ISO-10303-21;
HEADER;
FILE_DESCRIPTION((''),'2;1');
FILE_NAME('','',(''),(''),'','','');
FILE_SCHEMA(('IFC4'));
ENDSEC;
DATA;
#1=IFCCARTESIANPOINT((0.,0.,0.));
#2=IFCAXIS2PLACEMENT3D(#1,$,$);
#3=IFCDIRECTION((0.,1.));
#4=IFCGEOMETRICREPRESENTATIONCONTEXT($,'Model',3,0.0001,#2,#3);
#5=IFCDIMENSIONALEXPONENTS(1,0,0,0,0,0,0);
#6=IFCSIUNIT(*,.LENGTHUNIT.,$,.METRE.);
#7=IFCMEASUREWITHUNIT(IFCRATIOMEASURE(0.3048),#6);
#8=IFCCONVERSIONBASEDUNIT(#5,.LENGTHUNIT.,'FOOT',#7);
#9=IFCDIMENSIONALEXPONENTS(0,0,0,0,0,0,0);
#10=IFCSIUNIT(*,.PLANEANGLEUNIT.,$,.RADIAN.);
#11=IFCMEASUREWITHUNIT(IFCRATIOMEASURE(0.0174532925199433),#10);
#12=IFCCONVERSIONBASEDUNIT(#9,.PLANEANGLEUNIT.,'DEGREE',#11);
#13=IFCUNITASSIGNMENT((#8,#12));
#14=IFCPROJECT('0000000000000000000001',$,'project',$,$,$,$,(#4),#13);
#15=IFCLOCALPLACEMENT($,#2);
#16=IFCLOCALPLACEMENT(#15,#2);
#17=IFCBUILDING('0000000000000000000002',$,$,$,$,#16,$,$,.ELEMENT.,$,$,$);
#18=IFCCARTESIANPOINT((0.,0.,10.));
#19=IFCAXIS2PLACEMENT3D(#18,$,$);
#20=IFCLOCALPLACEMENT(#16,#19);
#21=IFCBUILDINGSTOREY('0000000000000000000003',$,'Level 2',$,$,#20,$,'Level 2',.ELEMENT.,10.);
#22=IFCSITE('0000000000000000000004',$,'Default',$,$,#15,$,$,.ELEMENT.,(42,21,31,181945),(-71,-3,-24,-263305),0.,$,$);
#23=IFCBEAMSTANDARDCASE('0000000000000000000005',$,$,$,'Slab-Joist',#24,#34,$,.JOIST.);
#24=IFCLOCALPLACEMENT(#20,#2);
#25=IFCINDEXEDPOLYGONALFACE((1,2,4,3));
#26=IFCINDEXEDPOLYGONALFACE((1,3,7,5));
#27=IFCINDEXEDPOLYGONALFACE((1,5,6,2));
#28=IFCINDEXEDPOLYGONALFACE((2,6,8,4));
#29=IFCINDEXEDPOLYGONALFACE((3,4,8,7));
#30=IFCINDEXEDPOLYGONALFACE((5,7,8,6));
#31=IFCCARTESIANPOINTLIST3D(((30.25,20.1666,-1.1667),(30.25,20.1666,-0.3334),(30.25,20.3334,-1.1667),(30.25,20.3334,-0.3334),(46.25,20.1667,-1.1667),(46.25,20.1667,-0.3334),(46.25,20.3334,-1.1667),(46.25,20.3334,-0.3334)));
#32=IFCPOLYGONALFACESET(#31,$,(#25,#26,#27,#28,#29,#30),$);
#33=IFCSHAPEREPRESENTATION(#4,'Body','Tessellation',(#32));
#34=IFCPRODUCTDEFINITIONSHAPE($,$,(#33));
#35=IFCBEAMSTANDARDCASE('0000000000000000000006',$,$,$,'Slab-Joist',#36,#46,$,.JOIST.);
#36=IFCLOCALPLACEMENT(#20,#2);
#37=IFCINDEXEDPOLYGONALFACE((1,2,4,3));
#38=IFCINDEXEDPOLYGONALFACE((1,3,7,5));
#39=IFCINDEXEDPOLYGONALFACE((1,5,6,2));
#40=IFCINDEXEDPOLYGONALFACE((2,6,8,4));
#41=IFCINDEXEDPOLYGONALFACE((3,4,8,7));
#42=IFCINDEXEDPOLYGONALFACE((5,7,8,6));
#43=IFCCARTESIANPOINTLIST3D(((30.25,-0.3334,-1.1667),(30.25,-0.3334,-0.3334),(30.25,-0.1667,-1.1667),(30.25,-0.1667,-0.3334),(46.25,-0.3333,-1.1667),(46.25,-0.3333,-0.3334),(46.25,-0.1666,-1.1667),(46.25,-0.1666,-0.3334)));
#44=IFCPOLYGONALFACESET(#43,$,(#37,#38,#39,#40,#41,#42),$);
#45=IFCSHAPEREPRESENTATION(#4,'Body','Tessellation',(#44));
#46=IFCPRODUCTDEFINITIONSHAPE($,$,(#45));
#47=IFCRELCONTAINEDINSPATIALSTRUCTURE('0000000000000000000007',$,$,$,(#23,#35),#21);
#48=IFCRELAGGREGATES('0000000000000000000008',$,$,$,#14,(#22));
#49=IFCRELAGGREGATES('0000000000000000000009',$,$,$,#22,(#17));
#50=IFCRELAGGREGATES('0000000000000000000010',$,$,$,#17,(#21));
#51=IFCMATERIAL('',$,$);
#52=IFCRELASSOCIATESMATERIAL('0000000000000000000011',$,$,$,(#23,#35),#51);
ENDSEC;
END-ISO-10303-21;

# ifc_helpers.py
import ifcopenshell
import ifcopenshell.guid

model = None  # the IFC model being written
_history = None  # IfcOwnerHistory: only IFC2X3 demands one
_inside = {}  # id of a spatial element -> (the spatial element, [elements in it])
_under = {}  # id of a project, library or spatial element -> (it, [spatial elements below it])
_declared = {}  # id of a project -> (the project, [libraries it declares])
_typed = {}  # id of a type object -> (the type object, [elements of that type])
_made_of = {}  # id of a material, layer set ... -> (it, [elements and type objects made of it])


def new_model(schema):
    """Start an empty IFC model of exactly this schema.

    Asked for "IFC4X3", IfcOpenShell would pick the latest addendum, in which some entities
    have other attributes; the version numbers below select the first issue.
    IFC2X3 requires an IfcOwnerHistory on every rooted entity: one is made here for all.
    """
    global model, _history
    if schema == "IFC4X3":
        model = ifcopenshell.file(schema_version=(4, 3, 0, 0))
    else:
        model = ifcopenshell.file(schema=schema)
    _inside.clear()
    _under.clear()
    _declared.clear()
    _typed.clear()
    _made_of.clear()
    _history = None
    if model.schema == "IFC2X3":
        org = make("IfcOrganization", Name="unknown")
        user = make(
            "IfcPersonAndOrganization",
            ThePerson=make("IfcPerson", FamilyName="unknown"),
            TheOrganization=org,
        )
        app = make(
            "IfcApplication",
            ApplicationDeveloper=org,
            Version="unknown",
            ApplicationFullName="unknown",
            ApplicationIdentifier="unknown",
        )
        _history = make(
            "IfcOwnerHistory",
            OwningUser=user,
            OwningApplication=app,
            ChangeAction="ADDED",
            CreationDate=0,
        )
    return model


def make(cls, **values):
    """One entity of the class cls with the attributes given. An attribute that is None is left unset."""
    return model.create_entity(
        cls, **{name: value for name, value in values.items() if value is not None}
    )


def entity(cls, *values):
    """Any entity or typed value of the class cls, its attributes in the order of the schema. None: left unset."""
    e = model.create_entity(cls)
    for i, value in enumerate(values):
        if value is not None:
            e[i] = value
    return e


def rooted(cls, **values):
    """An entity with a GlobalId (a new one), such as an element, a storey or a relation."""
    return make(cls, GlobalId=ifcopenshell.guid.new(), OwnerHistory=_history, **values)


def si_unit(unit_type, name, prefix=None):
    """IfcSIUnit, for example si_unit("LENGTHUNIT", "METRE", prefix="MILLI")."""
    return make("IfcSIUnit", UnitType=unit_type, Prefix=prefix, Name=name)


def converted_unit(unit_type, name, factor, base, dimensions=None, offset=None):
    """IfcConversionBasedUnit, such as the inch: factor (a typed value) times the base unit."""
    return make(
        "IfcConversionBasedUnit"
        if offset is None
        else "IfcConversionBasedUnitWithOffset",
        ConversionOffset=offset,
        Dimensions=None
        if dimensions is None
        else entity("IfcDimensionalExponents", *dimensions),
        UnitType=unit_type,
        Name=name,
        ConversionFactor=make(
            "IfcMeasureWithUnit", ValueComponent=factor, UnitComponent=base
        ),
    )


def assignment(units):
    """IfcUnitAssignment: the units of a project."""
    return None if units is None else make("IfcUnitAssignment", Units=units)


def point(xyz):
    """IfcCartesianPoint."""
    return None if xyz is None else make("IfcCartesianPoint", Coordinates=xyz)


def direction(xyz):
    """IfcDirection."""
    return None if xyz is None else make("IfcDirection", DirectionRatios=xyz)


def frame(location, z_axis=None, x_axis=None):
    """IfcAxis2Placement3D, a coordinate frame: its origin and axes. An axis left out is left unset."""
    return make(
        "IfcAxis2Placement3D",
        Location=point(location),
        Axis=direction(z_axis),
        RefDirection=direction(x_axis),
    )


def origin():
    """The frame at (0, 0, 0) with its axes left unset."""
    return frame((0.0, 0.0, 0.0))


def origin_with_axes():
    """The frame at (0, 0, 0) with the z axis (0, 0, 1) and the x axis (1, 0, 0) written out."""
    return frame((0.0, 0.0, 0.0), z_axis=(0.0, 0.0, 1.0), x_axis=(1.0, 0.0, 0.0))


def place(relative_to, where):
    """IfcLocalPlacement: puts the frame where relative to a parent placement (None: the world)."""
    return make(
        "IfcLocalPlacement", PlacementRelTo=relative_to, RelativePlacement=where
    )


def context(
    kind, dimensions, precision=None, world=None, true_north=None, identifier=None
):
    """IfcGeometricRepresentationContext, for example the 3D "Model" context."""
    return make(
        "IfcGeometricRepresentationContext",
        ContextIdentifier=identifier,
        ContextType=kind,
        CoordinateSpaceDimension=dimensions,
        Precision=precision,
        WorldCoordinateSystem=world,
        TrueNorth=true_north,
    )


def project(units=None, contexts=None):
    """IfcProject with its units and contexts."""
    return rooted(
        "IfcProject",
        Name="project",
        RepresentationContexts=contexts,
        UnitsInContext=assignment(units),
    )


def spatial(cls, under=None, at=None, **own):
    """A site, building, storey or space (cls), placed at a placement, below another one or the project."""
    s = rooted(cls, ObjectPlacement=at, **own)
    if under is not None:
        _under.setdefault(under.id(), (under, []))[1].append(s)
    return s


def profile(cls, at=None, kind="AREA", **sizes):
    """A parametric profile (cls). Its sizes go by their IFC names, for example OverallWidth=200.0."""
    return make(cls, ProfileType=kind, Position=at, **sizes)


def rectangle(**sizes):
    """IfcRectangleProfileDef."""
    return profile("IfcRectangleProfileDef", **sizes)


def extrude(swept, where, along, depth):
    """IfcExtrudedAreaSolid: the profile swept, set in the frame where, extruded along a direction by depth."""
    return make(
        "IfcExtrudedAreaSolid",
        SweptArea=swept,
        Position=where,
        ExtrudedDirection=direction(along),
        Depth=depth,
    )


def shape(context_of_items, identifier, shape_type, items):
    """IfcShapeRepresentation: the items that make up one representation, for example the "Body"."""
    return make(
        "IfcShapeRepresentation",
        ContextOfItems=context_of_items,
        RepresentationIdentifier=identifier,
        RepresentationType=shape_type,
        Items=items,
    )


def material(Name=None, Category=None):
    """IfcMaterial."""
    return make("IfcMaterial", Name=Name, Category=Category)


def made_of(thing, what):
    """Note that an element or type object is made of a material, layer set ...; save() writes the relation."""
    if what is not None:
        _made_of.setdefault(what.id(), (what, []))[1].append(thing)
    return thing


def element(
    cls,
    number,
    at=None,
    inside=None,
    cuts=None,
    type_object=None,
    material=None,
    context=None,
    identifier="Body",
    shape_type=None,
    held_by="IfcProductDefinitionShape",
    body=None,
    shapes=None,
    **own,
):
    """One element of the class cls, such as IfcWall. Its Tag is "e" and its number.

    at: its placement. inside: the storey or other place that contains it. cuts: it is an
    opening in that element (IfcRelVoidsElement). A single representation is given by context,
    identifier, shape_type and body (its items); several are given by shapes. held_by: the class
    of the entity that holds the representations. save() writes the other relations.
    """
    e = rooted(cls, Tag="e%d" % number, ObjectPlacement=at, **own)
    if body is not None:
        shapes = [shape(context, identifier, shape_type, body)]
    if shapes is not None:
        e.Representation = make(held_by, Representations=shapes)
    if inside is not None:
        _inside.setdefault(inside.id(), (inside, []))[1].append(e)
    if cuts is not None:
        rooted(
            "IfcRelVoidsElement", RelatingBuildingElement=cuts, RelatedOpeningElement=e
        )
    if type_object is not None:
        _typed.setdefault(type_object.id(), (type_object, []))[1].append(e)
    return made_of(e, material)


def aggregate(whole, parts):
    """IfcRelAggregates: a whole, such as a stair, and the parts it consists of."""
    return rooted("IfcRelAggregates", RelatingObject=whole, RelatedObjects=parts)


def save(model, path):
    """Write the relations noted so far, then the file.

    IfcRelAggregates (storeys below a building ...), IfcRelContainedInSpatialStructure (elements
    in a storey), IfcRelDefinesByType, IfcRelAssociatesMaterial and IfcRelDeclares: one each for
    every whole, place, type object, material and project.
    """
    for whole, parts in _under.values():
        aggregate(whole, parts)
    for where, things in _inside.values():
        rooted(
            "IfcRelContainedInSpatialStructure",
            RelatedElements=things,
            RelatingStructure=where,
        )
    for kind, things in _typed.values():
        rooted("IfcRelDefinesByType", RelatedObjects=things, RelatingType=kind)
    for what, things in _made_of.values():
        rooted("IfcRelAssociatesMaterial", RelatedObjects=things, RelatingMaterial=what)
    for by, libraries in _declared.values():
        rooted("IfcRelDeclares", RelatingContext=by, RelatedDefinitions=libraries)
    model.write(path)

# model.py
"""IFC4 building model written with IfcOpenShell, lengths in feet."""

from ifc_helpers import new_model, entity, si_unit, converted_unit, direction, frame, origin, origin_with_axes, place, context, project, spatial, rectangle, extrude, material, element, save


model = new_model("IFC4")

# Units and contexts
model_context = context("Model", 3, precision=0.0001, world=origin(), true_north=direction((0.0, 1.0)))
ifc_project = project(units=[converted_unit("LENGTHUNIT", "FOOT", entity("IfcRatioMeasure", 0.3048), si_unit("LENGTHUNIT", "METRE"), dimensions=[1, 0, 0, 0, 0, 0, 0]), converted_unit("PLANEANGLEUNIT", "DEGREE", entity("IfcRatioMeasure", 0.0174532925199433), si_unit("PLANEANGLEUNIT", "RADIAN"), dimensions=[0, 0, 0, 0, 0, 0, 0])], contexts=[model_context])

# Site, building, storey
site_placement = place(None, origin())
site = spatial("IfcSite", under=ifc_project, at=site_placement, Name="Default", CompositionType="ELEMENT", RefLatitude=(42, 21, 31, 181945), RefLongitude=(-71, -3, -24, -263305), RefElevation=0.0)
building_placement = place(site_placement, origin())
building = spatial("IfcBuilding", under=site, at=building_placement, CompositionType="ELEMENT")
storey_placement = place(building_placement, frame((0.0, 0.0, 10.0)))
storey = spatial("IfcBuildingStorey", under=building, at=storey_placement, Name="Level 2", LongName="Level 2", CompositionType="ELEMENT", Elevation=10.0)

# Beams
ifc_material = material(Name="")
placement_1 = place(storey_placement, frame((30.25, 20.25, 0.0), z_axis=(0.0, 0.0, 1.0), x_axis=(1.0, 0.0, 0.0)))
beam_1_placement = place(placement_1, frame((0.0, 0.0, -0.75), z_axis=(1.0, 0.0, 0.0), x_axis=(0.0, 1.0, 0.0)))
element("IfcBeamStandardCase", 1, at=beam_1_placement, inside=storey, material=ifc_material, ObjectType="Slab-Joist", PredefinedType="JOIST", context=model_context, shape_type="SweptSolid", body=[
    extrude(rectangle(XDim=0.1667, YDim=0.8333), origin_with_axes(), (0.0, 0.0, 1.0), 16.0),
])
placement_2 = place(storey_placement, frame((30.25, -0.25, 0.0), z_axis=(0.0, 0.0, 1.0), x_axis=(1.0, 0.0, 0.0)))
beam_2_placement = place(placement_2, frame((0.0, 0.0, -0.75), z_axis=(1.0, 0.0, 0.0), x_axis=(0.0, 1.0, 0.0)))
element("IfcBeamStandardCase", 2, at=beam_2_placement, inside=storey, material=ifc_material, ObjectType="Slab-Joist", PredefinedType="JOIST", context=model_context, shape_type="SweptSolid", body=[
    extrude(rectangle(XDim=0.1667, YDim=0.8333), origin_with_axes(), (0.0, 0.0, 1.0), 16.0),
])

save(model, "model.ifc")
